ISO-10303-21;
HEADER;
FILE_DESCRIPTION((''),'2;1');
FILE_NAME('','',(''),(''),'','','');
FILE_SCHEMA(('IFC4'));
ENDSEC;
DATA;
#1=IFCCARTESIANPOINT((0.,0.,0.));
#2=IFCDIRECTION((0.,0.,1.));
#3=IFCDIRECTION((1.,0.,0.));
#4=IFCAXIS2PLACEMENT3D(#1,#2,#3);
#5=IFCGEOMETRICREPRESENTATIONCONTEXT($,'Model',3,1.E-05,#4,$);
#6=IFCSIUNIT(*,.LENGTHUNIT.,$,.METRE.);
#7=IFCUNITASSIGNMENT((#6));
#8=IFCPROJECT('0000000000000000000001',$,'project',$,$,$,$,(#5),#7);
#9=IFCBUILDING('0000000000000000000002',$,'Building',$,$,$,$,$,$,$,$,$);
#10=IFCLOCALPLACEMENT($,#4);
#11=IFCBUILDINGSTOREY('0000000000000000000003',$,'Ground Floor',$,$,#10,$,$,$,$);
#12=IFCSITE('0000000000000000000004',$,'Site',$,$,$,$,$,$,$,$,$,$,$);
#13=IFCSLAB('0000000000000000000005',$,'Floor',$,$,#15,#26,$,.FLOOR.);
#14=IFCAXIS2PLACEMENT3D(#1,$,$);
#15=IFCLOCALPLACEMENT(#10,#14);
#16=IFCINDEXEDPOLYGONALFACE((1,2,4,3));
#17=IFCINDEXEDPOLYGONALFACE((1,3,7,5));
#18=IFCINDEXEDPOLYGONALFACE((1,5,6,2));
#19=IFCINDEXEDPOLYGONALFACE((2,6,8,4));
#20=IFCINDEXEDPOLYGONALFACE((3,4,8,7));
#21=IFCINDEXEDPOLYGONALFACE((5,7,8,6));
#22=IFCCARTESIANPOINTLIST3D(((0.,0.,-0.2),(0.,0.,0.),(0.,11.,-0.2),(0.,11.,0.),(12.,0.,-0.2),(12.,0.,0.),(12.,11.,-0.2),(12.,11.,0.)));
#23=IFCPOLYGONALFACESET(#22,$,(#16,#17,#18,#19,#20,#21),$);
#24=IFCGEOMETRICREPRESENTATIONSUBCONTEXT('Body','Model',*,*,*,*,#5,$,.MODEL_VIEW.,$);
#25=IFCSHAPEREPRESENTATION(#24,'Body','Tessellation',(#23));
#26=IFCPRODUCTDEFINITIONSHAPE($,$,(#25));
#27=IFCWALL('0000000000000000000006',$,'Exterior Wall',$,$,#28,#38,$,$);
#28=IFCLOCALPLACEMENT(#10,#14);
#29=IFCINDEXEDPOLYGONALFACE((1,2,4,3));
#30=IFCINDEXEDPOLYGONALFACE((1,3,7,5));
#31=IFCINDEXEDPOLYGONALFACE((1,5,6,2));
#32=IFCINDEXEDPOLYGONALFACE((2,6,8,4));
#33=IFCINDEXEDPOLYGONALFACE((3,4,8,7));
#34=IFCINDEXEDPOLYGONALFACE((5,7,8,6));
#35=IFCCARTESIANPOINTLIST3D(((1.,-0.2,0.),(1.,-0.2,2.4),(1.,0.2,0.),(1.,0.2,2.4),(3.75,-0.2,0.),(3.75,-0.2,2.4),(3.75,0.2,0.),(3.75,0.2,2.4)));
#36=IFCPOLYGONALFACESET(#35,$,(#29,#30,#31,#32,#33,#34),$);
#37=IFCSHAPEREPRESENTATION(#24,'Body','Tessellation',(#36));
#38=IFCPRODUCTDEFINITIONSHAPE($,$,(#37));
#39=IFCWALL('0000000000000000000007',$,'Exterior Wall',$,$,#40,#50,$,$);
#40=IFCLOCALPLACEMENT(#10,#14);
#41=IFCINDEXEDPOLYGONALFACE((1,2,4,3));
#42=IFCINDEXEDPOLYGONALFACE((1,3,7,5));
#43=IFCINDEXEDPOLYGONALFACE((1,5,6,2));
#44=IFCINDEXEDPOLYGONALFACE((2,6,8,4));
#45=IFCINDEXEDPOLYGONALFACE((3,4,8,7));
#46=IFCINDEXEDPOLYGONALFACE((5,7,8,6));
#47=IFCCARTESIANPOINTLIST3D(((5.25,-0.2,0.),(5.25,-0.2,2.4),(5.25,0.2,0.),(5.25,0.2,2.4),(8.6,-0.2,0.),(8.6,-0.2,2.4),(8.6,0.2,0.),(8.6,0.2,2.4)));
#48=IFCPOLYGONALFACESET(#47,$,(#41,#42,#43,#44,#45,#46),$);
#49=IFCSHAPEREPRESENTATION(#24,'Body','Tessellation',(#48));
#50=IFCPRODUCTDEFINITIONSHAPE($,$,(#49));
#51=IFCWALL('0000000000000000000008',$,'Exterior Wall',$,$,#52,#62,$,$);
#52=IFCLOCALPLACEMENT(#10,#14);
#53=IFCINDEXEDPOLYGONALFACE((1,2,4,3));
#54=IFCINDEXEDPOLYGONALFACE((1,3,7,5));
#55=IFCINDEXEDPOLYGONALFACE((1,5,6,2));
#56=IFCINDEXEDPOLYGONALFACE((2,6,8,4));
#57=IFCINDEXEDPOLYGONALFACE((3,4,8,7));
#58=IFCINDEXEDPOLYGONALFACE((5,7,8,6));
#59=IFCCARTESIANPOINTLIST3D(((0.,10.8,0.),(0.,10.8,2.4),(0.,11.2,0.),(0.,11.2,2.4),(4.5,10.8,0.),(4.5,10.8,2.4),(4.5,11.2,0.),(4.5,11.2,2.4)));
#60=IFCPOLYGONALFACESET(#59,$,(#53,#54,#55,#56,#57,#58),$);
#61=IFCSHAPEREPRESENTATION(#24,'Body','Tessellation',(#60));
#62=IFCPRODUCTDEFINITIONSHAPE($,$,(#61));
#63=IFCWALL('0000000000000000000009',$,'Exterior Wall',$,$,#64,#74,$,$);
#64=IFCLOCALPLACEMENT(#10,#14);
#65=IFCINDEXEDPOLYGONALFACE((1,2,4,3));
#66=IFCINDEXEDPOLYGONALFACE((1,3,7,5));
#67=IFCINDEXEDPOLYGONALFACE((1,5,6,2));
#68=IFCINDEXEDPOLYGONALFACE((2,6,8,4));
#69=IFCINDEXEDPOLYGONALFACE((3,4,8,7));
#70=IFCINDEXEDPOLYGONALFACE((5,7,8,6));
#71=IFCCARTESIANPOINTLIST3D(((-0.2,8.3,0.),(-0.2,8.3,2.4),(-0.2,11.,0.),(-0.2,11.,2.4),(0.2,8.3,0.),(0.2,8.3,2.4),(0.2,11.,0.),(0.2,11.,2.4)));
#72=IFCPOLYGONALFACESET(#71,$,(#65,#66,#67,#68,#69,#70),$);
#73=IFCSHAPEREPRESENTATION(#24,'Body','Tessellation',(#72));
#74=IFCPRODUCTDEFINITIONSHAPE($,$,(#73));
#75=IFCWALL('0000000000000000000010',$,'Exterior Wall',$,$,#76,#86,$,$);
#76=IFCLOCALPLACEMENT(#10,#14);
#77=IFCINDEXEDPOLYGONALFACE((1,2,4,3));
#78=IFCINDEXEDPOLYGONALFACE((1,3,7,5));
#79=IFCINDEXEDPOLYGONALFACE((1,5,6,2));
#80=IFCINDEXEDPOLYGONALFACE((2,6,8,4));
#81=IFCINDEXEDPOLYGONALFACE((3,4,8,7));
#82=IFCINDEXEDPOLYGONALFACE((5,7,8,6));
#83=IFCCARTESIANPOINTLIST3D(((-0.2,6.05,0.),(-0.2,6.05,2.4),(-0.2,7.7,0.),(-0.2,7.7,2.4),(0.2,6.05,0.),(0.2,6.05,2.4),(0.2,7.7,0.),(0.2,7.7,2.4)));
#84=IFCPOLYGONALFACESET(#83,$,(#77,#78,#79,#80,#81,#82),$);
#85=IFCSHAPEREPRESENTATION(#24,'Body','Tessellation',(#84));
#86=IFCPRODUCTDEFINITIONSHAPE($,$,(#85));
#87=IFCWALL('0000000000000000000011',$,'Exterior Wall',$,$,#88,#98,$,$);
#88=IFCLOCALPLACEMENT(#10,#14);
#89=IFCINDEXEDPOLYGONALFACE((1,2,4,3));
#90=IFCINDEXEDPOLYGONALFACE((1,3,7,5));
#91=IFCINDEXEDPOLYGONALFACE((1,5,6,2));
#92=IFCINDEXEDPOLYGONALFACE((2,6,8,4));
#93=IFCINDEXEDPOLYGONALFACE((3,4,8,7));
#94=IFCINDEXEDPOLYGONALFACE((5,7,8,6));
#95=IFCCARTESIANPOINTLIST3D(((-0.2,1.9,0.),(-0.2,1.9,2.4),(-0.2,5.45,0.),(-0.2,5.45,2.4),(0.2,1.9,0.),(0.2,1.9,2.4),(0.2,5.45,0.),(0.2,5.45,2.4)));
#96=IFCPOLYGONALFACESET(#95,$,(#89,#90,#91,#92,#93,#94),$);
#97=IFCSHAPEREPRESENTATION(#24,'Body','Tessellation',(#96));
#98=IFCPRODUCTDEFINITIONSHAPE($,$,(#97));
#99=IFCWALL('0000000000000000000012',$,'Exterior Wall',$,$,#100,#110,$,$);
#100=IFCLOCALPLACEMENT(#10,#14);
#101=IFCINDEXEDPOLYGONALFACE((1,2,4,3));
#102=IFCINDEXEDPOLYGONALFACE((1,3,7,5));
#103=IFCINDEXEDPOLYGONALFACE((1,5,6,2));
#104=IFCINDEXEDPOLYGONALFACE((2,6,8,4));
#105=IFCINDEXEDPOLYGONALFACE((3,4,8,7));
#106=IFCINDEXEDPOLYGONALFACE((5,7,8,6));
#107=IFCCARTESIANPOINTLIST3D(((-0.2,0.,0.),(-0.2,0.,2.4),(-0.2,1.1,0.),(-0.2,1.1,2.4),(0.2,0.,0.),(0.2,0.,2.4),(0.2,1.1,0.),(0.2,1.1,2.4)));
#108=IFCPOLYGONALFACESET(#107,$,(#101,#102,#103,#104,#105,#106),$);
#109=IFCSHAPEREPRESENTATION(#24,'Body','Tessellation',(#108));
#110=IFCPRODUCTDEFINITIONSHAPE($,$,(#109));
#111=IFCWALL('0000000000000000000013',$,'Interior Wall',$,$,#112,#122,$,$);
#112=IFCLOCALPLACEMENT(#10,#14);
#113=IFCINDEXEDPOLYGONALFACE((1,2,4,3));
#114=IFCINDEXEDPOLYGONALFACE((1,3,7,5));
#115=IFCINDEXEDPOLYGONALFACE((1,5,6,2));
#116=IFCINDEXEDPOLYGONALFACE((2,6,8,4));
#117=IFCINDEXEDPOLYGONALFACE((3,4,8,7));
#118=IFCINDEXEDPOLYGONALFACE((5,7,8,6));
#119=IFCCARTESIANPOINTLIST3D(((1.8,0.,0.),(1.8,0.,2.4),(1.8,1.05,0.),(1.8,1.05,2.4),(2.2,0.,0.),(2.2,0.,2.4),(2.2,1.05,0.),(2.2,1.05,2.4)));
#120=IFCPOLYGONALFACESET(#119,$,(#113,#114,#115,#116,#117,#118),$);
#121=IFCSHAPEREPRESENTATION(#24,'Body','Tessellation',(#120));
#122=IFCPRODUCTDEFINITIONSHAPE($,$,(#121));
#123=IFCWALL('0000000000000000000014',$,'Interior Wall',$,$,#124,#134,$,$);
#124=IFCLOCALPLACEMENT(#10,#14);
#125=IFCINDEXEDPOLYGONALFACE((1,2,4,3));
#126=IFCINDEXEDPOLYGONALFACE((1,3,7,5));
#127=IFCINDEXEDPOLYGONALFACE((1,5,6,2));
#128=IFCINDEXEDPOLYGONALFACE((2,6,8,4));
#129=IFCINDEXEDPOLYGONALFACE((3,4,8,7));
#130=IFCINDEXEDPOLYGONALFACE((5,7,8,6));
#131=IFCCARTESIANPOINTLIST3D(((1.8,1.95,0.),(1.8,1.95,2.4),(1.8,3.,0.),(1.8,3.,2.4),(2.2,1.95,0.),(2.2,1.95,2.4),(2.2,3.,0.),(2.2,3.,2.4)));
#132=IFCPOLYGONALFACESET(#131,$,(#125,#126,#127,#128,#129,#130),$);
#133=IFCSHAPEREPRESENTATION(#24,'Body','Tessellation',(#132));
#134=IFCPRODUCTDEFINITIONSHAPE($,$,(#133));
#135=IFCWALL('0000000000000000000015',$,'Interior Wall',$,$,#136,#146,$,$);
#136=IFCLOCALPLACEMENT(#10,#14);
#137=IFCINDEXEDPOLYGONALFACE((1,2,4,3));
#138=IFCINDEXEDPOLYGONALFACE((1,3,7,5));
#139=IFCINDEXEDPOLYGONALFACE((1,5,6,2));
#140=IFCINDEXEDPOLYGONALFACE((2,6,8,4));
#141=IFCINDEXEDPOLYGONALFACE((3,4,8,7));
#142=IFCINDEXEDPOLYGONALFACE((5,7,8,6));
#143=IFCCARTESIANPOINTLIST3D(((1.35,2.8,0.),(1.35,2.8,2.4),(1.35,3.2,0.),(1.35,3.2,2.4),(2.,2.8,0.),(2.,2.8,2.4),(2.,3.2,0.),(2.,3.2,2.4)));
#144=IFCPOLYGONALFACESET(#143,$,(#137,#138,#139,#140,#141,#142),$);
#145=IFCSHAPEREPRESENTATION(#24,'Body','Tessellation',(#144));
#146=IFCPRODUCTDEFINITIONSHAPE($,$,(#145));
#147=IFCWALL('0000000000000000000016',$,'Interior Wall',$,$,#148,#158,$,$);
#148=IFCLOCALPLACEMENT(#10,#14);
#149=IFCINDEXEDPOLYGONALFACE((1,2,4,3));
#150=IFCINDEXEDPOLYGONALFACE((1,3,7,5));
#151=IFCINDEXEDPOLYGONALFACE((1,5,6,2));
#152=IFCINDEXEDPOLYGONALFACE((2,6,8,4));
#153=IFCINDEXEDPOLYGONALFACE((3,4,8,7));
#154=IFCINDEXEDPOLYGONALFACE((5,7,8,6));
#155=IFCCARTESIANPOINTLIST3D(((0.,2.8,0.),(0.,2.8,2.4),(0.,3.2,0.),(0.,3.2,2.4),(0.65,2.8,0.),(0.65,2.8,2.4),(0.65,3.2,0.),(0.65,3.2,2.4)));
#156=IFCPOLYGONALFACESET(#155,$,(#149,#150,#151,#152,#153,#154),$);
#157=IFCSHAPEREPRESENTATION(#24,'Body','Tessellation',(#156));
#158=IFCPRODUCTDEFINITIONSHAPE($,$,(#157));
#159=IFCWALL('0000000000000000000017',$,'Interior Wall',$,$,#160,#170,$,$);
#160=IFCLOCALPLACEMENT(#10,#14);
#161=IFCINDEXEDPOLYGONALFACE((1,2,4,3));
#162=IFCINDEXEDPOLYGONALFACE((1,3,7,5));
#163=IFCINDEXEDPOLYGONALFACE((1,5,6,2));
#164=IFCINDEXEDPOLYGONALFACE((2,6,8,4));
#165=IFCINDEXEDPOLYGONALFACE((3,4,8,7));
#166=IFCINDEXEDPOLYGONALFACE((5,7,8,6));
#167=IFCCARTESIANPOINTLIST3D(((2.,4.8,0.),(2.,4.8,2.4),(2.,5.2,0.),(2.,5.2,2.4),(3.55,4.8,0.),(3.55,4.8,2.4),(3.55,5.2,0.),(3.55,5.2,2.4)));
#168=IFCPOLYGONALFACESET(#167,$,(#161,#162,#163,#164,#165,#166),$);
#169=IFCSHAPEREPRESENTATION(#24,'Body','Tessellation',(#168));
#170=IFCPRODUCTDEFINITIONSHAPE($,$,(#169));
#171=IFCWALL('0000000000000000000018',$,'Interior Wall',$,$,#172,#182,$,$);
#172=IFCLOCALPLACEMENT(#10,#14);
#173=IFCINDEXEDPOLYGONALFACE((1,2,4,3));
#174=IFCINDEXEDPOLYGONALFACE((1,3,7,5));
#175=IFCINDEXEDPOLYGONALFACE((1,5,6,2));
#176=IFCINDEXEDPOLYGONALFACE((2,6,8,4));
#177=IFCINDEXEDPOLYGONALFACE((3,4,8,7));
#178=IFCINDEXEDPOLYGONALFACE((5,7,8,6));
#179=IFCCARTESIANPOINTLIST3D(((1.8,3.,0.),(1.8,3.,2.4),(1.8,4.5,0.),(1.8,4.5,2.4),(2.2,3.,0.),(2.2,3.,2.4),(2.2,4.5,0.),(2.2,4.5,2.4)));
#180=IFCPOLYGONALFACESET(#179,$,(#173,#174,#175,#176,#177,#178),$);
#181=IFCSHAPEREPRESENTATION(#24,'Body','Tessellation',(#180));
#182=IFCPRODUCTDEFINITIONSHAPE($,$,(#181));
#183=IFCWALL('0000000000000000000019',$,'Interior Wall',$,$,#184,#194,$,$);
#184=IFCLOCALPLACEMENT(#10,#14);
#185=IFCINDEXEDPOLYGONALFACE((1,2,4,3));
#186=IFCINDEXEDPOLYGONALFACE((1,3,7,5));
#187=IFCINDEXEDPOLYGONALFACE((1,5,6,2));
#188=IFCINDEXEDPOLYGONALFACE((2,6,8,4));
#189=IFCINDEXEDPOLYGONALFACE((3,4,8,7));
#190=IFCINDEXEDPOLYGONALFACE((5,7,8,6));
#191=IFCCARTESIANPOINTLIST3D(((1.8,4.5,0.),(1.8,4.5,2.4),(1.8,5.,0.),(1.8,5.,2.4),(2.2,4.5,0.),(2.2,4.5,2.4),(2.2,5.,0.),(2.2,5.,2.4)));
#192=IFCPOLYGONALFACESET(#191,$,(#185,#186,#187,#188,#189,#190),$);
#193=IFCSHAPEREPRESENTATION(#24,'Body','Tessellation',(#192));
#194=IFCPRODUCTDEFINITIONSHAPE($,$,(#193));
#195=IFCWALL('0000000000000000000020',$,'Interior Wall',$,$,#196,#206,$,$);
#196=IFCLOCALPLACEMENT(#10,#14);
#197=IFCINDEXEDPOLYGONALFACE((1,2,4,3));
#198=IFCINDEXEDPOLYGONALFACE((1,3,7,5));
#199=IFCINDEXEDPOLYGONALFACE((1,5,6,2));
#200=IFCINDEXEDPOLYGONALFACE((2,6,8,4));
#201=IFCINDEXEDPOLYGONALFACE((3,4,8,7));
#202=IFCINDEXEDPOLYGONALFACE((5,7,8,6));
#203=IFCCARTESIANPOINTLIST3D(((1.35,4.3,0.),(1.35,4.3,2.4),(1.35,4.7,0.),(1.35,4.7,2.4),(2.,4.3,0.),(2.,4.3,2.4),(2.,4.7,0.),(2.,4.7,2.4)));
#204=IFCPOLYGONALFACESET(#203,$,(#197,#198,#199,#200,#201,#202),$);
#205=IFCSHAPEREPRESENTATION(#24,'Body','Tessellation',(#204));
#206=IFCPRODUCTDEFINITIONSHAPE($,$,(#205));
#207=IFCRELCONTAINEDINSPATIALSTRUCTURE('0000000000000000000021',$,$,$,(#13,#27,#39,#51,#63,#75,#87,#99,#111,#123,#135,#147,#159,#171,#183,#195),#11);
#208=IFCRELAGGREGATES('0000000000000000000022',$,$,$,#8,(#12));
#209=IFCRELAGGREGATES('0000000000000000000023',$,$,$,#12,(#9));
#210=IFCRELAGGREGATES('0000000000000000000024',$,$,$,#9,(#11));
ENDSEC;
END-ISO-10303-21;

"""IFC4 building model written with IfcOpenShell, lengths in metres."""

from ifc_helpers import new_model, si_unit, frame, origin_with_axes, place, context, subcontext, project, spatial, indexed_curve, outline, extrude, element, save


model = new_model("IFC4")

# Units and contexts
model_context = context("Model", 3, precision=1e-05, world=origin_with_axes())
body_context = subcontext(model_context, "Body", "Model", "MODEL_VIEW")
ifc_project = project(units=[si_unit("LENGTHUNIT", "METRE")], contexts=[model_context])

# Site, building, storey
site = spatial("IfcSite", under=ifc_project, Name="Site")
building = spatial("IfcBuilding", under=site, Name="Building")
storey_placement = place(None, origin_with_axes())
storey = spatial("IfcBuildingStorey", under=building, at=storey_placement, Name="Ground Floor")

# Slab
slab_placement = place(storey_placement, frame((0.0, 0.0, -0.2), z_axis=(0.0, 0.0, 1.0), x_axis=(1.0, 0.0, 0.0)))
element("IfcSlab", 1, at=slab_placement, inside=storey, Name="Floor", PredefinedType="FLOOR", context=body_context, shape_type="SweptSolid", body=[
    extrude(outline(indexed_curve([(0.0, 0.0), (12.0, 0.0), (12.0, 11.0), (0.0, 11.0)])), None, (0.0, 0.0, 1.0), 0.2),
])

# Walls
wall_1_placement = place(storey_placement, frame((1.0, 0.0, 0.0), z_axis=(0.0, 0.0, 1.0), x_axis=(1.0, 0.0, 0.0)))
element("IfcWall", 2, at=wall_1_placement, inside=storey, Name="Exterior Wall", context=body_context, shape_type="SweptSolid", body=[
    extrude(outline(indexed_curve([(0.0, 0.0), (0.0, 0.4), (2.75, 0.4), (2.75, 0.0), (0.0, 0.0)], self_intersect=False)), frame((0.0, -0.2, 0.0), z_axis=(0.0, 0.0, 1.0), x_axis=(1.0, 0.0, 0.0)), (0.0, 0.0, 1.0), 2.4),
])
wall_2_placement = place(storey_placement, frame((5.25, 0.0, 0.0), z_axis=(0.0, 0.0, 1.0), x_axis=(1.0, 0.0, 0.0)))
element("IfcWall", 3, at=wall_2_placement, inside=storey, Name="Exterior Wall", context=body_context, shape_type="SweptSolid", body=[
    extrude(outline(indexed_curve([(0.0, 0.0), (0.0, 0.4), (3.35, 0.4), (3.35, 0.0), (0.0, 0.0)], self_intersect=False)), frame((0.0, -0.2, 0.0), z_axis=(0.0, 0.0, 1.0), x_axis=(1.0, 0.0, 0.0)), (0.0, 0.0, 1.0), 2.4),
])
wall_3_placement = place(storey_placement, frame((4.5, 11.0, 0.0), z_axis=(0.0, 0.0, 1.0), x_axis=(-1.0, 0.0, 0.0)))
element("IfcWall", 4, at=wall_3_placement, inside=storey, Name="Exterior Wall", context=body_context, shape_type="SweptSolid", body=[
    extrude(outline(indexed_curve([(0.0, 0.0), (0.0, 0.4), (4.5, 0.4), (4.5, 0.0), (0.0, 0.0)], self_intersect=False)), frame((0.0, -0.2, 0.0), z_axis=(0.0, 0.0, 1.0), x_axis=(1.0, 0.0, 0.0)), (0.0, 0.0, 1.0), 2.4),
])
wall_4_placement = place(storey_placement, frame((0.0, 11.0, 0.0), z_axis=(0.0, 0.0, 1.0), x_axis=(0.0, -1.0, 0.0)))
element("IfcWall", 5, at=wall_4_placement, inside=storey, Name="Exterior Wall", context=body_context, shape_type="SweptSolid", body=[
    extrude(outline(indexed_curve([(0.0, 0.0), (0.0, 0.4), (2.7, 0.4), (2.7, 0.0), (0.0, 0.0)], self_intersect=False)), frame((0.0, -0.2, 0.0), z_axis=(0.0, 0.0, 1.0), x_axis=(1.0, 0.0, 0.0)), (0.0, 0.0, 1.0), 2.4),
])
wall_5_placement = place(storey_placement, frame((0.0, 7.7, 0.0), z_axis=(0.0, 0.0, 1.0), x_axis=(0.0, -1.0, 0.0)))
element("IfcWall", 6, at=wall_5_placement, inside=storey, Name="Exterior Wall", context=body_context, shape_type="SweptSolid", body=[
    extrude(outline(indexed_curve([(0.0, 0.0), (0.0, 0.4), (1.65, 0.4), (1.65, 0.0), (0.0, 0.0)], self_intersect=False)), frame((0.0, -0.2, 0.0), z_axis=(0.0, 0.0, 1.0), x_axis=(1.0, 0.0, 0.0)), (0.0, 0.0, 1.0), 2.4),
])
wall_6_placement = place(storey_placement, frame((0.0, 5.45, 0.0), z_axis=(0.0, 0.0, 1.0), x_axis=(0.0, -1.0, 0.0)))
element("IfcWall", 7, at=wall_6_placement, inside=storey, Name="Exterior Wall", context=body_context, shape_type="SweptSolid", body=[
    extrude(outline(indexed_curve([(0.0, 0.0), (0.0, 0.4), (3.55, 0.4), (3.55, 0.0), (0.0, 0.0)], self_intersect=False)), frame((0.0, -0.2, 0.0), z_axis=(0.0, 0.0, 1.0), x_axis=(1.0, 0.0, 0.0)), (0.0, 0.0, 1.0), 2.4),
])
wall_7_placement = place(storey_placement, frame((0.0, 1.1, 0.0), z_axis=(0.0, 0.0, 1.0), x_axis=(0.0, -1.0, 0.0)))
element("IfcWall", 8, at=wall_7_placement, inside=storey, Name="Exterior Wall", context=body_context, shape_type="SweptSolid", body=[
    extrude(outline(indexed_curve([(0.0, 0.0), (0.0, 0.4), (1.1, 0.4), (1.1, 0.0), (0.0, 0.0)], self_intersect=False)), frame((0.0, -0.2, 0.0), z_axis=(0.0, 0.0, 1.0), x_axis=(1.0, 0.0, 0.0)), (0.0, 0.0, 1.0), 2.4),
])
for number, where, z_axis, x_axis, name in (
    (9, (2.0, 0.0, 0.0), (0.0, 0.0, 1.0), (0.0, 1.0, 0.0), "Interior Wall"),
    (10, (2.0, 1.95, 0.0), (0.0, 0.0, 1.0), (0.0, 1.0, 0.0), "Interior Wall"),
):
    element("IfcWall", number, at=place(storey_placement, frame(where, z_axis=z_axis, x_axis=x_axis)), inside=storey, Name=name, context=body_context, shape_type="SweptSolid", body=[
        extrude(outline(indexed_curve([(0.0, 0.0), (0.0, 0.4), (1.05, 0.4), (1.05, 0.0), (0.0, 0.0)], self_intersect=False)), frame((0.0, -0.2, 0.0), z_axis=(0.0, 0.0, 1.0), x_axis=(1.0, 0.0, 0.0)), (0.0, 0.0, 1.0), 2.4),
    ])
for number, where, z_axis, x_axis, name in (
    (11, (2.0, 3.0, 0.0), (0.0, 0.0, 1.0), (-1.0, 0.0, 0.0), "Interior Wall"),
    (12, (0.65, 3.0, 0.0), (0.0, 0.0, 1.0), (-1.0, 0.0, 0.0), "Interior Wall"),
):
    element("IfcWall", number, at=place(storey_placement, frame(where, z_axis=z_axis, x_axis=x_axis)), inside=storey, Name=name, context=body_context, shape_type="SweptSolid", body=[
        extrude(outline(indexed_curve([(0.0, 0.0), (0.0, 0.4), (0.65, 0.4), (0.65, 0.0), (0.0, 0.0)], self_intersect=False)), frame((0.0, -0.2, 0.0), z_axis=(0.0, 0.0, 1.0), x_axis=(1.0, 0.0, 0.0)), (0.0, 0.0, 1.0), 2.4),
    ])
wall_8_placement = place(storey_placement, frame((3.55, 5.0, 0.0), z_axis=(0.0, 0.0, 1.0), x_axis=(-1.0, 0.0, 0.0)))
element("IfcWall", 13, at=wall_8_placement, inside=storey, Name="Interior Wall", context=body_context, shape_type="SweptSolid", body=[
    extrude(outline(indexed_curve([(0.0, 0.0), (0.0, 0.4), (1.55, 0.4), (1.55, 0.0), (0.0, 0.0)], self_intersect=False)), frame((0.0, -0.2, 0.0), z_axis=(0.0, 0.0, 1.0), x_axis=(1.0, 0.0, 0.0)), (0.0, 0.0, 1.0), 2.4),
])
wall_9_placement = place(storey_placement, frame((2.0, 4.5, 0.0), z_axis=(0.0, 0.0, 1.0), x_axis=(0.0, -1.0, 0.0)))
element("IfcWall", 14, at=wall_9_placement, inside=storey, Name="Interior Wall", context=body_context, shape_type="SweptSolid", body=[
    extrude(outline(indexed_curve([(0.0, 0.0), (0.0, 0.4), (1.5, 0.4), (1.5, 0.0), (0.0, 0.0)], self_intersect=False)), frame((0.0, -0.2, 0.0), z_axis=(0.0, 0.0, 1.0), x_axis=(1.0, 0.0, 0.0)), (0.0, 0.0, 1.0), 2.4),
])
wall_10_placement = place(storey_placement, frame((2.0, 5.0, 0.0), z_axis=(0.0, 0.0, 1.0), x_axis=(0.0, -1.0, 0.0)))
element("IfcWall", 15, at=wall_10_placement, inside=storey, Name="Interior Wall", context=body_context, shape_type="SweptSolid", body=[
    extrude(outline(indexed_curve([(0.0, 0.0), (0.0, 0.4), (0.5, 0.4), (0.5, 0.0), (0.0, 0.0)], self_intersect=False)), frame((0.0, -0.2, 0.0), z_axis=(0.0, 0.0, 1.0), x_axis=(1.0, 0.0, 0.0)), (0.0, 0.0, 1.0), 2.4),
])
for number, where, z_axis, x_axis, name in (
    (16, (2.0, 4.5, 0.0), (0.0, 0.0, 1.0), (-1.0, 0.0, 0.0), "Interior Wall"),
):
    element("IfcWall", number, at=place(storey_placement, frame(where, z_axis=z_axis, x_axis=x_axis)), inside=storey, Name=name, context=body_context, shape_type="SweptSolid", body=[
        extrude(outline(indexed_curve([(0.0, 0.0), (0.0, 0.4), (0.65, 0.4), (0.65, 0.0), (0.0, 0.0)], self_intersect=False)), frame((0.0, -0.2, 0.0), z_axis=(0.0, 0.0, 1.0), x_axis=(1.0, 0.0, 0.0)), (0.0, 0.0, 1.0), 2.4),
    ])

save(model, "model.ifc")
